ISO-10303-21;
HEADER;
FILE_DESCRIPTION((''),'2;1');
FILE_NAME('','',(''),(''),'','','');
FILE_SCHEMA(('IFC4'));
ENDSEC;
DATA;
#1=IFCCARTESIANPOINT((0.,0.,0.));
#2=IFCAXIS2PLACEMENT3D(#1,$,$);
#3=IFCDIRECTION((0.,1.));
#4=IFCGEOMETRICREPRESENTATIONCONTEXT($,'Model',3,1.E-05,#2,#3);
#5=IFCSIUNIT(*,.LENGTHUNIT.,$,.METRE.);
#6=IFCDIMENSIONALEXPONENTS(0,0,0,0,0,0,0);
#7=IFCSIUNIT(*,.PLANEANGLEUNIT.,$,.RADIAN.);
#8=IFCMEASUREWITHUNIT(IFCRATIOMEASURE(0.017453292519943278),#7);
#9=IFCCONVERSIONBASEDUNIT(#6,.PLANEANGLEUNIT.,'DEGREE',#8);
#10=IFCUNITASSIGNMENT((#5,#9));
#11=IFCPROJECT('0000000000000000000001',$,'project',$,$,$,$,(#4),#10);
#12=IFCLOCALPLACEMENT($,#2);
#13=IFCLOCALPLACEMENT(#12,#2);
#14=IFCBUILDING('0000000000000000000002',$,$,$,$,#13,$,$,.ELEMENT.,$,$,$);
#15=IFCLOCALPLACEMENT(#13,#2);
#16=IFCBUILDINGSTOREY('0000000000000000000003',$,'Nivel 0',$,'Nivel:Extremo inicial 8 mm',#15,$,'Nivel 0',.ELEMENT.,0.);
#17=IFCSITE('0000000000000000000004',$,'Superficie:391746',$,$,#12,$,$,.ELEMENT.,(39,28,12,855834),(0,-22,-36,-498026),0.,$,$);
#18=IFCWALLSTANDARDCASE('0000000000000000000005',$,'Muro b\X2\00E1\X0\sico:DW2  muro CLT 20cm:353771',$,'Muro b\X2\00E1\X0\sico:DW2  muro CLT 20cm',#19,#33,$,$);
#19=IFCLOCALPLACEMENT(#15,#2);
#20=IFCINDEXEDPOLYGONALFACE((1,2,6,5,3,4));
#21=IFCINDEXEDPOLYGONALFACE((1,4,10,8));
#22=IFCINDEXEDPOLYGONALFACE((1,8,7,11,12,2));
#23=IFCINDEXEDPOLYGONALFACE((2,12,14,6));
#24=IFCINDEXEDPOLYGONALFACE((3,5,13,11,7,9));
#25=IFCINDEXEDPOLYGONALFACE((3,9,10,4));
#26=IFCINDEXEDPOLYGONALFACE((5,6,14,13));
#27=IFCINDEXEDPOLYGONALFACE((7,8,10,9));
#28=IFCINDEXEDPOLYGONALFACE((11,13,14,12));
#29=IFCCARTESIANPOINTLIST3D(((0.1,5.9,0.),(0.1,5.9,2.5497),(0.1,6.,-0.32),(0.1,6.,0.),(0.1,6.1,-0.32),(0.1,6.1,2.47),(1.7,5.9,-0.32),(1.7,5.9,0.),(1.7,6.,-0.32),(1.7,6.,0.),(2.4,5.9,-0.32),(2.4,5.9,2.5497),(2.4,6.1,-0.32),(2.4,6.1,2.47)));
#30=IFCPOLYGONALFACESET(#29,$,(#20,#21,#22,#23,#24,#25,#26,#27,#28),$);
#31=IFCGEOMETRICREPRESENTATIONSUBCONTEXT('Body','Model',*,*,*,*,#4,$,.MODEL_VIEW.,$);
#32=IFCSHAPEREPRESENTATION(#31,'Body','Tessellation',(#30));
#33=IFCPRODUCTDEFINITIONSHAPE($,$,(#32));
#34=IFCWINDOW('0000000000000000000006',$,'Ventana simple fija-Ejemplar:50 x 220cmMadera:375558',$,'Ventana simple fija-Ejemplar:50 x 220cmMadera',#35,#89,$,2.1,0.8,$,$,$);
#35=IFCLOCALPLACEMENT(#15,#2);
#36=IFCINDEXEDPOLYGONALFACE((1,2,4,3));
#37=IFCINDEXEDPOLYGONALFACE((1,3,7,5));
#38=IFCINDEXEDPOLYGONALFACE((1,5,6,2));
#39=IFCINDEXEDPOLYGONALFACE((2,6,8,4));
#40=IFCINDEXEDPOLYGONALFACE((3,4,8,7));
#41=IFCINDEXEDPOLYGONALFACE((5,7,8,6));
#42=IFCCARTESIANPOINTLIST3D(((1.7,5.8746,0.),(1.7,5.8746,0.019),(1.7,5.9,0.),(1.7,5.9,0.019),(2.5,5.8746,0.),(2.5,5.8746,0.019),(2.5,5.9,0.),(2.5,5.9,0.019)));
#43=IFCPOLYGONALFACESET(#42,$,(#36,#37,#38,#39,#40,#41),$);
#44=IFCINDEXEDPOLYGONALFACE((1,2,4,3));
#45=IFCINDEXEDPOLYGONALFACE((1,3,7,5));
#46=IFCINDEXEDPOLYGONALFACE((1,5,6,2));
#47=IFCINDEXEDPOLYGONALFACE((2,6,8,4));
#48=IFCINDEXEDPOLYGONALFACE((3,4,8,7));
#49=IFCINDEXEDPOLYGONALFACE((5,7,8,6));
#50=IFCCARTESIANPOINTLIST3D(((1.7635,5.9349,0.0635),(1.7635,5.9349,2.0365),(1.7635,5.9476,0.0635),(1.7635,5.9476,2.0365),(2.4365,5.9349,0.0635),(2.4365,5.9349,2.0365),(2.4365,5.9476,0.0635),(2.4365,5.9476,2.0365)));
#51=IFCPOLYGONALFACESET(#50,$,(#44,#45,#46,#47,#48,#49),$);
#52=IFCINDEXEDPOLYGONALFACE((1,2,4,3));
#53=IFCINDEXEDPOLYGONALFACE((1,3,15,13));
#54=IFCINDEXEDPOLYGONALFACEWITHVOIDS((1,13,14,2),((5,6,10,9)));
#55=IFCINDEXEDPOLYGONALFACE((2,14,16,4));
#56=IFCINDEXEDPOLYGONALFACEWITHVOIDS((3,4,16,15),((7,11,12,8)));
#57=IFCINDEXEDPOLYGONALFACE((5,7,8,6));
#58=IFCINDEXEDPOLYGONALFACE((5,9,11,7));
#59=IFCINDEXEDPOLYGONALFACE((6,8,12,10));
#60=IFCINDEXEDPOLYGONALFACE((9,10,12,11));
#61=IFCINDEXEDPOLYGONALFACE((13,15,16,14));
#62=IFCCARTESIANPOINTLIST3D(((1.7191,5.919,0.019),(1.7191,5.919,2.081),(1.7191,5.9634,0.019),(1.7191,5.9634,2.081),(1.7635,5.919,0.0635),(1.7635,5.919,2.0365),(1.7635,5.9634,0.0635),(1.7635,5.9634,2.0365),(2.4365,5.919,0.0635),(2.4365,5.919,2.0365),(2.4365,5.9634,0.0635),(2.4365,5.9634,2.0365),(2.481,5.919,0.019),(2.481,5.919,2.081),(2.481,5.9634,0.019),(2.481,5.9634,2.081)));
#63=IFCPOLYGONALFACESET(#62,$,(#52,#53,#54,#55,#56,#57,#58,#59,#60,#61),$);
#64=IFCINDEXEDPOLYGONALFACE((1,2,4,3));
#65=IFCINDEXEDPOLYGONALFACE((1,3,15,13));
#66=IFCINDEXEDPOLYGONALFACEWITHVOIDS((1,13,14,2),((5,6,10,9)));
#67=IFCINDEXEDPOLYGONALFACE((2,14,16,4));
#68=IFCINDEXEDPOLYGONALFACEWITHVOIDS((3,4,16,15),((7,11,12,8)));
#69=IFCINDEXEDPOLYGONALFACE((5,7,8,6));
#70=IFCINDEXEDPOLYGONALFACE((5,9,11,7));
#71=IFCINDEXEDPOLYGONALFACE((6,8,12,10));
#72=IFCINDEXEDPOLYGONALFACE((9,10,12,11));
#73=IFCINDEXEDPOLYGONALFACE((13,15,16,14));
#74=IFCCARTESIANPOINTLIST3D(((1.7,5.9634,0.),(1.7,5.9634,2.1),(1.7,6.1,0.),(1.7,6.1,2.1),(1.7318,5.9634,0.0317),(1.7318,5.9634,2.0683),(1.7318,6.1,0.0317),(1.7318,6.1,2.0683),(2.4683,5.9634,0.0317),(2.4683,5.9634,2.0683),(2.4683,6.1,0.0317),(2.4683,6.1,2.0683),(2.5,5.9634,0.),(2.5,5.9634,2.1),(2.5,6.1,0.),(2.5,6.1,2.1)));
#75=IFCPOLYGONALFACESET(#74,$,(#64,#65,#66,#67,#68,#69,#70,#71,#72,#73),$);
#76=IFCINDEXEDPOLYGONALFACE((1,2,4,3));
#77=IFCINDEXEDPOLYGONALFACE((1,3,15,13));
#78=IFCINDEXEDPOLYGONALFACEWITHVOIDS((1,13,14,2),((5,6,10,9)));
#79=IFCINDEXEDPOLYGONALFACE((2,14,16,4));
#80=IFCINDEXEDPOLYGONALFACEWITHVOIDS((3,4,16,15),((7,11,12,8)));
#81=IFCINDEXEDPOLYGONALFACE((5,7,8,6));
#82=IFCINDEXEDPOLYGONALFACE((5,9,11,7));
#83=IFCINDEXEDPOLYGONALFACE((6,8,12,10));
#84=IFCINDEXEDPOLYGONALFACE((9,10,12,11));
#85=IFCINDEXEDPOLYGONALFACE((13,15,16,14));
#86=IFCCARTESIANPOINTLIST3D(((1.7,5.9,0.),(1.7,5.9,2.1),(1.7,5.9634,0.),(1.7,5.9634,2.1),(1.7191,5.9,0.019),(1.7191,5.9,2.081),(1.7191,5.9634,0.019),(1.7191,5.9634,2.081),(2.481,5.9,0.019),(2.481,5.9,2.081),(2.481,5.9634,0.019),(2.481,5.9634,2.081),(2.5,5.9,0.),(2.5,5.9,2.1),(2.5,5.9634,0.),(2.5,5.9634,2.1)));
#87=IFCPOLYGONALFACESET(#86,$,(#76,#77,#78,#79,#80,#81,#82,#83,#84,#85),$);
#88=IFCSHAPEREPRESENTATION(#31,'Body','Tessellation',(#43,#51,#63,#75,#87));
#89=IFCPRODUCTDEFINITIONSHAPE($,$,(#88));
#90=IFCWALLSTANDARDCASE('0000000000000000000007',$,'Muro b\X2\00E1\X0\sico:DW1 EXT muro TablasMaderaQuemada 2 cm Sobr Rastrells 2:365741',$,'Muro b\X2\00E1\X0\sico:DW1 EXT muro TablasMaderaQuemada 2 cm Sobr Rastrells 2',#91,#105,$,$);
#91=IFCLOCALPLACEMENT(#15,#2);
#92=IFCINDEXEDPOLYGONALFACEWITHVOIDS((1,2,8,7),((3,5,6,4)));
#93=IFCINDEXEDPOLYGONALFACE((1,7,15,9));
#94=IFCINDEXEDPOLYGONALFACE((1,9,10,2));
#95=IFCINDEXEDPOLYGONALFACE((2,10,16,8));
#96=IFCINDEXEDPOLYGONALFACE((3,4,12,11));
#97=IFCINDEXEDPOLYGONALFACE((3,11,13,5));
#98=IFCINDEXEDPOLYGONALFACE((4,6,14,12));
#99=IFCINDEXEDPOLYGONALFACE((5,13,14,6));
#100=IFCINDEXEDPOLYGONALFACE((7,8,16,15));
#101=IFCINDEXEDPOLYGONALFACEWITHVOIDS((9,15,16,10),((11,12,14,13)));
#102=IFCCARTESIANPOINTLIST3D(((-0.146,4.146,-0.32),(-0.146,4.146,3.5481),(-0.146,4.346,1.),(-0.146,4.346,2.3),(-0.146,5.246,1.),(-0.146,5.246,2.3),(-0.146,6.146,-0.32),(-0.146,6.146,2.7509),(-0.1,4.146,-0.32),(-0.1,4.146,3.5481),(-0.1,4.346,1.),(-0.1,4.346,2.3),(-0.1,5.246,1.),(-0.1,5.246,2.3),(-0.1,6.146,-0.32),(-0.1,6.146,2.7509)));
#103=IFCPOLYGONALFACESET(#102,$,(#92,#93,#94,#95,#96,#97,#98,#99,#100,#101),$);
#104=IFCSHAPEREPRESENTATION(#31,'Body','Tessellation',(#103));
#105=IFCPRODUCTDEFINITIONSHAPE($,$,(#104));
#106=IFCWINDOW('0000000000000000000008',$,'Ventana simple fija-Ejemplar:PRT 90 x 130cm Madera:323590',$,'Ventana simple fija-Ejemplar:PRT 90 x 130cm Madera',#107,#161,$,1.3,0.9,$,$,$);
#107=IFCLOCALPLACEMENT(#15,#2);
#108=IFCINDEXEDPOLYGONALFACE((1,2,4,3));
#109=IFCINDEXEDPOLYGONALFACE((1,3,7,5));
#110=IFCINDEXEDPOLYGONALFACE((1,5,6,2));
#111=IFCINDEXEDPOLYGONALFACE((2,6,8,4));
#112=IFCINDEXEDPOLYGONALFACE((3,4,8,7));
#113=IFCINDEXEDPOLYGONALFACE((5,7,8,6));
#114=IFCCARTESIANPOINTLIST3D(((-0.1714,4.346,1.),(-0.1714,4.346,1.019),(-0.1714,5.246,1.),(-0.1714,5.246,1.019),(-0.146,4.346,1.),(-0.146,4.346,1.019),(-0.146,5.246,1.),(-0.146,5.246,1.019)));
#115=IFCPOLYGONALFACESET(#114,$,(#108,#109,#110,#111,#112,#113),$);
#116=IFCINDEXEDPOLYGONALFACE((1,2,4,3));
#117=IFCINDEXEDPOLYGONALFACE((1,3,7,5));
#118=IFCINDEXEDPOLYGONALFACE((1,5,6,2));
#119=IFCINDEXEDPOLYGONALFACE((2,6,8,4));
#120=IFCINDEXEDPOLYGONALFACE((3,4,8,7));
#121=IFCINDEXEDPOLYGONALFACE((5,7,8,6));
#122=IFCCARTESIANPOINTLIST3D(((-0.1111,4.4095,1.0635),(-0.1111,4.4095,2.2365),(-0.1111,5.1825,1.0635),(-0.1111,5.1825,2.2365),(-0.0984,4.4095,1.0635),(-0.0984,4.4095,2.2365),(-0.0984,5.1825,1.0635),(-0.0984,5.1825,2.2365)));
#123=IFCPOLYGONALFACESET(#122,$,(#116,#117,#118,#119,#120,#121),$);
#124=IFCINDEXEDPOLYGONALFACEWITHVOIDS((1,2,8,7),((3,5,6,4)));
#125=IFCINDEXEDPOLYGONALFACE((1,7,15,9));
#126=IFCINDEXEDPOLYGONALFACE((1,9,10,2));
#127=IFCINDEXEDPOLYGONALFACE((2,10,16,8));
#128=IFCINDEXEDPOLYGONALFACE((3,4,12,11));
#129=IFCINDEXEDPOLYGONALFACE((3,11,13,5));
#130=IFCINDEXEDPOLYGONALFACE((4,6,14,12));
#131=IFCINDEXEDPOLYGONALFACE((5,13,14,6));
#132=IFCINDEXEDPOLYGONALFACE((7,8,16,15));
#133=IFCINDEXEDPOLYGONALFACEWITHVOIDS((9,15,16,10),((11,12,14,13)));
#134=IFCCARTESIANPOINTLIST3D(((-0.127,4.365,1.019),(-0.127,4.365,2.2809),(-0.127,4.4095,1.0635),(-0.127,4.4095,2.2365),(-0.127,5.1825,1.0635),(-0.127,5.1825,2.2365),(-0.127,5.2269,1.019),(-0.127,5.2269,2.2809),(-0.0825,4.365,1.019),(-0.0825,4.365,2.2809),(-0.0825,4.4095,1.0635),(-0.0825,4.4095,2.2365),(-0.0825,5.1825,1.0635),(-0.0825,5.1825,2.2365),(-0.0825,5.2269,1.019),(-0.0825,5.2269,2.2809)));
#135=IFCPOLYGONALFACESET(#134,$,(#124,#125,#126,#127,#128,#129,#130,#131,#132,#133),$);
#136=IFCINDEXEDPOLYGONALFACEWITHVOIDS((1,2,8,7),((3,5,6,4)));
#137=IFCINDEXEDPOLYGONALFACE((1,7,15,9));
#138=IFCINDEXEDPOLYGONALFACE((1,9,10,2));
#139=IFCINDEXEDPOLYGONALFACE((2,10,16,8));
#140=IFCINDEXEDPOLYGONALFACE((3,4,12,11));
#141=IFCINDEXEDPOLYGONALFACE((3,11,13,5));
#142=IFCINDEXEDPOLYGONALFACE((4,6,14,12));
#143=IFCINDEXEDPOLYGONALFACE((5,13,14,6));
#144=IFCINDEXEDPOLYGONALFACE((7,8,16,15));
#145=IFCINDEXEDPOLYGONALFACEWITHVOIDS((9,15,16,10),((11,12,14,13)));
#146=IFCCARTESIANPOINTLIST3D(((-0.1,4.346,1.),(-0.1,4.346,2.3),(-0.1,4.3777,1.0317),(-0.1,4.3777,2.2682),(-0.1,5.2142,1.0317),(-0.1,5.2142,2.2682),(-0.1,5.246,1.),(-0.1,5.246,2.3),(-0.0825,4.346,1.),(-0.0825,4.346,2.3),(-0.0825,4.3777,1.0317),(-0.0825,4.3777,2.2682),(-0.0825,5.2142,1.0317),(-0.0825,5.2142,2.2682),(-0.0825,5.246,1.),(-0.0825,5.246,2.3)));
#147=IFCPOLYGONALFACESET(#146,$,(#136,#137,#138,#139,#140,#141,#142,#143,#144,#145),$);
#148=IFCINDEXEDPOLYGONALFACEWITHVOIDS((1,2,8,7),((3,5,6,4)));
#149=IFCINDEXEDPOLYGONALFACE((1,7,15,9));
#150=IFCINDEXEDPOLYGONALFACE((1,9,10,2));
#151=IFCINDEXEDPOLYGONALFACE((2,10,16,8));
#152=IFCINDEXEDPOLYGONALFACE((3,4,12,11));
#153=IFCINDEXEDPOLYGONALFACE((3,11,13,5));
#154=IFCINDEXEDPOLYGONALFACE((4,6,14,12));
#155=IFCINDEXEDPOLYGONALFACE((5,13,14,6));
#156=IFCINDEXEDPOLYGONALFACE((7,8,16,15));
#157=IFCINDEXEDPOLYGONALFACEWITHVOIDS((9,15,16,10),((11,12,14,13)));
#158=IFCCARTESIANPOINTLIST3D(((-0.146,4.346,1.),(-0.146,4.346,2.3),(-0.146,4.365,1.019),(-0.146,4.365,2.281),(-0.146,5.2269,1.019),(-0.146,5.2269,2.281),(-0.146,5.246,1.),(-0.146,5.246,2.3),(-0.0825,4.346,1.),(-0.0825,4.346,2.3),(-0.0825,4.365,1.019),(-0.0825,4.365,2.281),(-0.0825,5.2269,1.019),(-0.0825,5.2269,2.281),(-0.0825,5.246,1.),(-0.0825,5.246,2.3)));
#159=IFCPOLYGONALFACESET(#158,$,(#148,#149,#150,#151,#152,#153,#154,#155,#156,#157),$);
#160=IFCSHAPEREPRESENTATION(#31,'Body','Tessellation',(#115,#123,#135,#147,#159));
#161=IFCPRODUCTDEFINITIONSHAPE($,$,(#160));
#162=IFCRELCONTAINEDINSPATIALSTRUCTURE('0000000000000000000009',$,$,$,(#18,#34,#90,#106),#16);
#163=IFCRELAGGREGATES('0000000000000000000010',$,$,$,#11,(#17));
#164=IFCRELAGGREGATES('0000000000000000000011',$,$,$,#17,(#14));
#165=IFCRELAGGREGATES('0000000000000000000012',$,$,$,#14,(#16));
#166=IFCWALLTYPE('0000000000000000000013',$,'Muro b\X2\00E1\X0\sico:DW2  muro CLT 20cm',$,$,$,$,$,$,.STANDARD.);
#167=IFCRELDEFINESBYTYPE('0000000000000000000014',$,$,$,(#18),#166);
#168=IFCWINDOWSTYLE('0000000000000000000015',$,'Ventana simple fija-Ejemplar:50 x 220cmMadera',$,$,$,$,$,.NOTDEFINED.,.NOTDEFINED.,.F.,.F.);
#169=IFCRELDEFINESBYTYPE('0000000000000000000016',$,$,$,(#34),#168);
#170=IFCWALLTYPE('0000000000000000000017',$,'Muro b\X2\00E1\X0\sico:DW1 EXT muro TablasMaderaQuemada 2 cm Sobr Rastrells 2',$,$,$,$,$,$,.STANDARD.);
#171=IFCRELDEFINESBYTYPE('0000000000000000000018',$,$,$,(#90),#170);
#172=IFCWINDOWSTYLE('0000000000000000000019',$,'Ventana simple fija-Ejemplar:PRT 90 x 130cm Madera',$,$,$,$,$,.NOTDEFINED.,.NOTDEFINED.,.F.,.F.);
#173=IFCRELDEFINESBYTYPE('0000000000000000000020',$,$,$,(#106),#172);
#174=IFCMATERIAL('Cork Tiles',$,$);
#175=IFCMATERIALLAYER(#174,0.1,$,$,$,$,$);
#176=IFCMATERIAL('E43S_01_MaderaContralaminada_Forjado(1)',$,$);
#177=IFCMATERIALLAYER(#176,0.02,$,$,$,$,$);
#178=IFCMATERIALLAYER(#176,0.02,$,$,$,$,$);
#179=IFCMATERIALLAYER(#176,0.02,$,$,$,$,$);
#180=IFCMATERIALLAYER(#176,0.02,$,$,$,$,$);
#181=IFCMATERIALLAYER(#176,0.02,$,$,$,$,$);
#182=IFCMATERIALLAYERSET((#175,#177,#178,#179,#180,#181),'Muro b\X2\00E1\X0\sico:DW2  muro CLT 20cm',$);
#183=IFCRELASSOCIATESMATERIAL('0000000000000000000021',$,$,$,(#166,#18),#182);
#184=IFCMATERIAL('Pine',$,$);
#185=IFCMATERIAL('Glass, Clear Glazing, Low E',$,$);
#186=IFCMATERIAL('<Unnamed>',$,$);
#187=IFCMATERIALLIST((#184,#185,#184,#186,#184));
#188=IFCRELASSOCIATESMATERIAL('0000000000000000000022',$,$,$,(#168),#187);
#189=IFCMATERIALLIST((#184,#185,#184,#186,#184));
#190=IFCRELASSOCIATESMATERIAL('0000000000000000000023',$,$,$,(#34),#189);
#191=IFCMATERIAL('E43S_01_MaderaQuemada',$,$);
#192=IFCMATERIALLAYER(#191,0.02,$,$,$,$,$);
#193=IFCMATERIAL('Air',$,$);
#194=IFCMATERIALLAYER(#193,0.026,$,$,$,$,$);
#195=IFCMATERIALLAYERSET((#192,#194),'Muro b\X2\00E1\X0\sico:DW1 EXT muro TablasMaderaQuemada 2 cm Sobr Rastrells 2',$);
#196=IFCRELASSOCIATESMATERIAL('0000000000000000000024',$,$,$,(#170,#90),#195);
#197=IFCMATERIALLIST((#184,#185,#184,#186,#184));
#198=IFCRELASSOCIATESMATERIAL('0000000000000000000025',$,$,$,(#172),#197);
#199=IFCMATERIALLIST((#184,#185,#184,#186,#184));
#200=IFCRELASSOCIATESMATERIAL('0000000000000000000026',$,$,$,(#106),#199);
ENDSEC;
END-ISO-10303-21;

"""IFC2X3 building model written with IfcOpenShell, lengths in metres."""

from ifc_helpers import new_model, entity, si_unit, converted_unit, direction, frame, frame_2d, origin, origin_2d_with_axis, place, context, subcontext, project, spatial, polyline, rectangle, outline, extrude, clip, bounded_halfspace, source, transform, mapped, material, material_list, layer, layer_set, layer_usage, type_object, type_shapes, element, fill, save


model = new_model("IFC2X3")

# Units and contexts
model_context = context("Model", 3, precision=1e-05, world=origin(), true_north=direction((0.0, 1.0)))
body_context = subcontext(model_context, "Body", "Model", "MODEL_VIEW")
ifc_project = project(units=[si_unit("LENGTHUNIT", "METRE"), converted_unit("PLANEANGLEUNIT", "DEGREE", entity("IfcRatioMeasure", 0.017453292519943278), si_unit("PLANEANGLEUNIT", "RADIAN"), dimensions=[0, 0, 0, 0, 0, 0, 0])], contexts=[model_context])

# Site, building, storey
site_placement = place(None, origin())
site = spatial("IfcSite", under=ifc_project, at=site_placement, Name="Superficie:391746", CompositionType="ELEMENT", RefLatitude=(39, 28, 12, 855834), RefLongitude=(0, -22, -36, -498026), RefElevation=0.0)
building_placement = place(site_placement, origin())
building = spatial("IfcBuilding", under=site, at=building_placement, CompositionType="ELEMENT")
storey_placement = place(building_placement, origin())
storey = spatial("IfcBuildingStorey", under=building, at=storey_placement, Name="Nivel 0", ObjectType="Nivel:Extremo inicial 8 mm", LongName="Nivel 0", CompositionType="ELEMENT", Elevation=0.0)

# Shared definitions
ifc_material_1 = material(Name="E43S_01_MaderaContralaminada_Forjado(1)")

# Shared definitions
ifc_material_2 = material(Name="Cork Tiles")

# Wall, opening, window
ifc_layer_1 = layer(ifc_material_2, 0.1)
ifc_layer_2 = layer(ifc_material_1, 0.02)
ifc_layer_3 = layer(ifc_material_1, 0.02)
ifc_layer_4 = layer(ifc_material_1, 0.02)
ifc_layer_5 = layer(ifc_material_1, 0.02)
ifc_layer_6 = layer(ifc_material_1, 0.02)
ifc_layer_set_1 = layer_set([ifc_layer_1, ifc_layer_2, ifc_layer_3, ifc_layer_4, ifc_layer_5, ifc_layer_6], Name="Muro básico:DW2  muro CLT 20cm")
ifc_layer_usage_1 = layer_usage(ifc_layer_set_1, "AXIS2", "NEGATIVE", 0.1)
wall_type_1 = type_object("IfcWallType", Name="Muro básico:DW2  muro CLT 20cm", PredefinedType="STANDARD", material=ifc_layer_set_1)
wall_1_placement = place(storey_placement, frame((0.1, 6.0, -0.32)))
wall_1 = element("IfcWallStandardCase", 1, at=wall_1_placement, inside=storey, type_object=wall_type_1, material=ifc_layer_usage_1, Name="Muro básico:DW2  muro CLT 20cm:353771", ObjectType="Muro básico:DW2  muro CLT 20cm", context=body_context, shape_type="Clipping", body=[
    clip(clip(extrude(rectangle(XDim=0.2, YDim=2.3, at=frame_2d((1.15, 0.0), x_axis=(0.0, -1.0))), origin(), (0.0, 0.0, 1.0), 2.8697), bounded_halfspace(frame((0.0, 0.1, 2.79), z_axis=(0.0, 0.370288, 0.928917), x_axis=(-1.0, 0.0, 0.0)), False, frame((0.0, 0.1, 2.79)), polyline([(0.0, 0.0), (0.0, -0.2), (2.3, -0.2), (2.3, 0.0), (0.0, 0.0)]))), bounded_halfspace(frame((0.0, -0.1, 0.32), z_axis=(0.0, 0.0, -1.0), x_axis=(0.0, 1.0, 0.0)), False, frame((0.0, -0.1, 0.32)), polyline([(0.0, 0.0), (1.6, 0.0), (1.6, 0.1), (0.0, 0.1), (0.0, 0.0)]))),
])
opening_1_placement = place(wall_1_placement, frame((2.4, 0.1, 0.32)))
opening_1 = element("IfcOpeningElement", 2, at=opening_1_placement, cuts=wall_1, ObjectType="Opening", context=body_context, shape_type="SweptSolid", body=[
    extrude(rectangle(XDim=2.1, YDim=0.8, at=frame_2d((1.05, 0.4), x_axis=(-1.0, 0.0))), frame((0.0, 0.0, 0.0), z_axis=(0.0, -1.0, 0.0), x_axis=(0.0, 0.0, 1.0)), (0.0, 0.0, 1.0), 0.2),
])
ifc_material_3 = material(Name="Pine")
ifc_material_4 = material(Name="Glass, Clear Glazing, Low E")
ifc_material_5 = material(Name="<Unnamed>")
ifc_material_list_1 = material_list([ifc_material_3, ifc_material_4, ifc_material_3, ifc_material_5, ifc_material_3])
ifc_material_list_2 = material_list([ifc_material_3, ifc_material_4, ifc_material_3, ifc_material_5, ifc_material_3])
window_style_1 = type_object("IfcWindowStyle", Name="Ventana simple fija-Ejemplar:50 x 220cmMadera", ConstructionType="NOTDEFINED", OperationType="NOTDEFINED", ParameterTakesPrecedence=False, Sizeable=False, material=ifc_material_list_2)
shared_shape_1 = source(origin(), body_context, "Body", "SweptSolid", [
    extrude(rectangle(XDim=0.8, YDim=0.0254, at=origin_2d_with_axis()), frame((0.4762, 0.2127, 0.0), z_axis=(0.0, 0.0, 1.0), x_axis=(-1.0, 0.0, 0.0)), (0.0, 0.0, 1.0), 0.019),
    extrude(rectangle(XDim=0.673, YDim=0.0127, at=frame_2d((0.0, 0.0), x_axis=(1.0, 0.0))), frame((0.4762, 0.1588, 0.0635)), (0.0, 0.0, 1.0), 1.973),
    extrude(outline(polyline([(-0.3809, -1.031), (0.3809, -1.031), (0.3809, 1.031), (-0.3809, 1.031), (-0.3809, -1.031)]), holes=[polyline([(-0.3365, -0.9865), (-0.3365, 0.9865), (0.3365, 0.9865), (0.3365, -0.9865), (-0.3365, -0.9865)])]), frame((0.4762, 0.181, 1.05), z_axis=(0.0, -1.0, 0.0), x_axis=(-1.0, 0.0, 0.0)), (0.0, 0.0, 1.0), 0.0444),
    extrude(outline(polyline([(-0.4, -1.05), (0.4, -1.05), (0.4, 1.05), (-0.4, 1.05), (-0.4, -1.05)]), holes=[polyline([(-0.3683, -1.0183), (-0.3683, 1.0183), (0.3682, 1.0183), (0.3682, -1.0183), (-0.3683, -1.0183)])]), frame((0.4762, 0.1365, 1.05), z_axis=(0.0, -1.0, 0.0), x_axis=(-1.0, 0.0, 0.0)), (0.0, 0.0, 1.0), 0.1365),
    extrude(outline(polyline([(-1.05, -0.4), (1.05, -0.4), (1.05, 0.4), (-1.05, 0.4), (-1.05, -0.4)]), holes=[polyline([(-1.031, -0.3809), (-1.031, 0.381), (1.031, 0.381), (1.031, -0.3809), (-1.031, -0.3809)])]), frame((0.4762, 0.2, 1.05), z_axis=(0.0, -1.0, 0.0), x_axis=(0.0, 0.0, -1.0)), (0.0, 0.0, 1.0), 0.0635),
])
type_shapes(window_style_1, [shared_shape_1])
window_1_placement = place(opening_1_placement, frame((0.0762, 0.0, 0.0), z_axis=(0.0, 0.0, 1.0), x_axis=(-1.0, 0.0, 0.0)))
window_1 = element("IfcWindow", 3, at=window_1_placement, inside=storey, type_object=window_style_1, material=ifc_material_list_1, Name="Ventana simple fija-Ejemplar:50 x 220cmMadera:375558", ObjectType="Ventana simple fija-Ejemplar:50 x 220cmMadera", OverallHeight=2.1, OverallWidth=0.8, context=body_context, shape_type="MappedRepresentation", body=[
    mapped(shared_shape_1, transform((0.0, 0.0, 0.0), scale=1.0)),
])
fill(opening_1, window_1)

# Wall, opening, window
ifc_material_6 = material(Name="E43S_01_MaderaQuemada")
ifc_layer_7 = layer(ifc_material_6, 0.02)
ifc_material_7 = material(Name="Air")
ifc_layer_8 = layer(ifc_material_7, 0.026)
ifc_layer_set_2 = layer_set([ifc_layer_7, ifc_layer_8], Name="Muro básico:DW1 EXT muro TablasMaderaQuemada 2 cm Sobr Rastrells 2")
ifc_layer_usage_2 = layer_usage(ifc_layer_set_2, "AXIS2", "NEGATIVE", 0.023)
wall_type_2 = type_object("IfcWallType", Name="Muro básico:DW1 EXT muro TablasMaderaQuemada 2 cm Sobr Rastrells 2", PredefinedType="STANDARD", material=ifc_layer_set_2)
wall_2_placement = place(storey_placement, frame((-0.123, 4.146, -0.32), z_axis=(0.0, 0.0, 1.0), x_axis=(0.0, 1.0, 0.0)))
wall_2 = element("IfcWallStandardCase", 4, at=wall_2_placement, inside=storey, type_object=wall_type_2, material=ifc_layer_usage_2, Name="Muro básico:DW1 EXT muro TablasMaderaQuemada 2 cm Sobr Rastrells 2:365741", ObjectType="Muro básico:DW1 EXT muro TablasMaderaQuemada 2 cm Sobr Rastrells 2", context=body_context, shape_type="Clipping", body=[
    clip(extrude(rectangle(XDim=2.0, YDim=0.046, at=frame_2d((1.0, 0.0), x_axis=(1.0, 0.0))), origin(), (0.0, 0.0, 1.0), 3.8681), bounded_halfspace(frame((0.0, -0.023, 3.8681), z_axis=(0.370288, 0.0, 0.928917), x_axis=(0.0, 1.0, 0.0)), False, frame((0.0, -0.023, 3.8681)), polyline([(0.0, 0.0), (0.046, 0.0), (1.954, 0.0), (2.0, 0.0), (2.0, 0.046), (0.0, 0.046), (0.0, 0.0)]))),
])
opening_2_placement = place(wall_2_placement, frame((0.2, -0.023, 1.32)))
opening_2 = element("IfcOpeningElement", 5, at=opening_2_placement, cuts=wall_2, ObjectType="Opening", context=body_context, shape_type="SweptSolid", body=[
    extrude(rectangle(XDim=1.3, YDim=0.9, at=frame_2d((0.65, 0.45), x_axis=(-1.0, 0.0))), frame((0.0, 0.0, 0.0), z_axis=(0.0, 1.0, 0.0), x_axis=(0.0, 0.0, 1.0)), (0.0, 0.0, 1.0), 0.046),
])
ifc_material_list_3 = material_list([ifc_material_3, ifc_material_4, ifc_material_3, ifc_material_5, ifc_material_3])
ifc_material_list_4 = material_list([ifc_material_3, ifc_material_4, ifc_material_3, ifc_material_5, ifc_material_3])
window_style_2 = type_object("IfcWindowStyle", Name="Ventana simple fija-Ejemplar:PRT 90 x 130cm Madera", ConstructionType="NOTDEFINED", OperationType="NOTDEFINED", ParameterTakesPrecedence=False, Sizeable=False, material=ifc_material_list_4)
shared_shape_2 = source(origin(), body_context, "Body", "SweptSolid", [
    extrude(rectangle(XDim=0.9, YDim=0.0254, at=origin_2d_with_axis()), frame((0.5262, 0.0587, 0.0), z_axis=(0.0, 0.0, 1.0), x_axis=(-1.0, 0.0, 0.0)), (0.0, 0.0, 1.0), 0.019),
    extrude(rectangle(XDim=0.773, YDim=0.0127, at=origin_2d_with_axis()), frame((0.5262, 0.0048, 0.0635)), (0.0, 0.0, 1.0), 1.173),
    extrude(outline(polyline([(-0.431, -0.631), (0.431, -0.631), (0.431, 0.631), (-0.431, 0.631), (-0.431, -0.631)]), holes=[polyline([(-0.3865, -0.5865), (-0.3865, 0.5865), (0.3865, 0.5865), (0.3865, -0.5865), (-0.3865, -0.5865)])]), frame((0.5262, 0.027, 0.65), z_axis=(0.0, -1.0, 0.0), x_axis=(-1.0, 0.0, 0.0)), (0.0, 0.0, 1.0), 0.0444),
    extrude(outline(polyline([(-0.45, -0.65), (0.45, -0.65), (0.45, 0.65), (-0.45, 0.65), (-0.45, -0.65)]), holes=[polyline([(-0.4183, -0.6182), (-0.4183, 0.6183), (0.4183, 0.6183), (0.4183, -0.6182), (-0.4183, -0.6182)])]), frame((0.5262, 0.0, 0.65), z_axis=(0.0, -1.0, 0.0), x_axis=(-1.0, 0.0, 0.0)), (0.0, 0.0, 1.0), 0.0175),
    extrude(outline(polyline([(-0.65, -0.45), (0.65, -0.45), (0.65, 0.45), (-0.65, 0.45), (-0.65, -0.45)]), holes=[polyline([(-0.6309, -0.431), (-0.6309, 0.431), (0.631, 0.431), (0.631, -0.431), (-0.6309, -0.431)])]), frame((0.5262, 0.046, 0.65), z_axis=(0.0, -1.0, 0.0), x_axis=(0.0, 0.0, -1.0)), (0.0, 0.0, 1.0), 0.0635),
])
type_shapes(window_style_2, [shared_shape_2])
window_2_placement = place(opening_2_placement, frame((-0.0762, 0.0, 0.0)))
window_2 = element("IfcWindow", 6, at=window_2_placement, inside=storey, type_object=window_style_2, material=ifc_material_list_3, Name="Ventana simple fija-Ejemplar:PRT 90 x 130cm Madera:323590", ObjectType="Ventana simple fija-Ejemplar:PRT 90 x 130cm Madera", OverallHeight=1.3, OverallWidth=0.9, context=body_context, shape_type="MappedRepresentation", body=[
    mapped(shared_shape_2, transform((0.0, 0.0, 0.0), scale=1.0)),
])
fill(opening_2, window_2)

save(model, "model.ifc")
